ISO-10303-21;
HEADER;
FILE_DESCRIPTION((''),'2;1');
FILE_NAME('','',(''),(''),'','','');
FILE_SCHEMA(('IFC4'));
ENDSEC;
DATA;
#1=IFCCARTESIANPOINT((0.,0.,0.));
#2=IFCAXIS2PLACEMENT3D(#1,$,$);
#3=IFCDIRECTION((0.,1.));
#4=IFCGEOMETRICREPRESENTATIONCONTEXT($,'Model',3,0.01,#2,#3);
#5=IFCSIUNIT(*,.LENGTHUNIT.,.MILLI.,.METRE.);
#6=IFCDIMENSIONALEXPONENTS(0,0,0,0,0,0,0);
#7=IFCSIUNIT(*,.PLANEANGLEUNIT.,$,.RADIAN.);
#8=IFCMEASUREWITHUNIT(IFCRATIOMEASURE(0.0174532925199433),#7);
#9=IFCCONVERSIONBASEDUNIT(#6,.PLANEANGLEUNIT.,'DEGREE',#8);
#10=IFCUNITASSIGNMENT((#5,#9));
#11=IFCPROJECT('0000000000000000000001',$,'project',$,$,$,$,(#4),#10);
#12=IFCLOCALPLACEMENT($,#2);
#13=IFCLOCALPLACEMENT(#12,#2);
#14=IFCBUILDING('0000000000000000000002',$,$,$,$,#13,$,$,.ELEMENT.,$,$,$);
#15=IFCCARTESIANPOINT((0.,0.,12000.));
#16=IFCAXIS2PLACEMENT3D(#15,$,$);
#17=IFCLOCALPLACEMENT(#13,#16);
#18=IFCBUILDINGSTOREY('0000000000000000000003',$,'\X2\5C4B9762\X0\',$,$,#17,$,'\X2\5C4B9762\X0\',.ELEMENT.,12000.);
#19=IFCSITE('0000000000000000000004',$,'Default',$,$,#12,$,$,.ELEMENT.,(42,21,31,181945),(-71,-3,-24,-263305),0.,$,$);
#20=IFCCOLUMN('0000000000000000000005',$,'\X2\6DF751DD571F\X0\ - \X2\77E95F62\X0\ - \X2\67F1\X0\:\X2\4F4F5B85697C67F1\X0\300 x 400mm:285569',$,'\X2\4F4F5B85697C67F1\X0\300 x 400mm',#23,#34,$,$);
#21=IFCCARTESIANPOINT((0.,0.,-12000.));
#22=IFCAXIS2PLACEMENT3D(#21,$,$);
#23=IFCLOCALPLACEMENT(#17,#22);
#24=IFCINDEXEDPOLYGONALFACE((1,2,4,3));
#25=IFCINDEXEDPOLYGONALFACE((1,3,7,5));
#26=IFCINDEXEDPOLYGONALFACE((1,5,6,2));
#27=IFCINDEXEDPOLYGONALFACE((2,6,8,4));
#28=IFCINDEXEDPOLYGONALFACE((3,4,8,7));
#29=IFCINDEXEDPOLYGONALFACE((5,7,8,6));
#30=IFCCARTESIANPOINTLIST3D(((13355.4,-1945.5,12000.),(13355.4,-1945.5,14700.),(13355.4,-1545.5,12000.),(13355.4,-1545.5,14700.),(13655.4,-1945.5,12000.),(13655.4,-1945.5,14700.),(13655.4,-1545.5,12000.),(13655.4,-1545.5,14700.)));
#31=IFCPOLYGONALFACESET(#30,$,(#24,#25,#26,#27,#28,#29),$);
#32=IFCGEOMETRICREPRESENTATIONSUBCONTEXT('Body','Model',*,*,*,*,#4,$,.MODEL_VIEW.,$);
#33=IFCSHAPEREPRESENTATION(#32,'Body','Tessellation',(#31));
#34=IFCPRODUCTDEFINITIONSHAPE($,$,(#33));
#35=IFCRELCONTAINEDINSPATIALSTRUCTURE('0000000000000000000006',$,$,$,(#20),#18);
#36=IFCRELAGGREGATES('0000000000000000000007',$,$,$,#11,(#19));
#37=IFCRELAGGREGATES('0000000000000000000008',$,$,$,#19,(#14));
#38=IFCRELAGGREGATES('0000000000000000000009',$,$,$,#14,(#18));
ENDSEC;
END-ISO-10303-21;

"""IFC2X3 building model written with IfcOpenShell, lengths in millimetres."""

from ifc_helpers import new_model, entity, si_unit, converted_unit, direction, frame, origin, origin_2d_with_axis, place, context, subcontext, project, spatial, rectangle, extrude, source, transform, mapped, element, save


model = new_model("IFC2X3")

# Units and contexts
model_context = context("Model", 3, precision=0.01, world=origin(), true_north=direction((0.0, 1.0)))
body_context = subcontext(model_context, "Body", "Model", "MODEL_VIEW")
ifc_project = project(units=[si_unit("LENGTHUNIT", "METRE", prefix="MILLI"), converted_unit("PLANEANGLEUNIT", "DEGREE", entity("IfcRatioMeasure", 0.0174532925199433), si_unit("PLANEANGLEUNIT", "RADIAN"), dimensions=[0, 0, 0, 0, 0, 0, 0])], contexts=[model_context])

# Site, building, storey
site_placement = place(None, origin())
site = spatial("IfcSite", under=ifc_project, at=site_placement, Name="Default", CompositionType="ELEMENT", RefLatitude=(42, 21, 31, 181945), RefLongitude=(-71, -3, -24, -263305), RefElevation=0.0)
building_placement = place(site_placement, origin())
building = spatial("IfcBuilding", under=site, at=building_placement, CompositionType="ELEMENT")
storey_placement = place(building_placement, frame((0.0, 0.0, 12000.0)))
storey = spatial("IfcBuildingStorey", under=building, at=storey_placement, Name="屋面", LongName="屋面", CompositionType="ELEMENT", Elevation=12000.0)

# Column
shared_shape = source(origin(), body_context, "Body", "SweptSolid", [
    extrude(rectangle(XDim=400.0, YDim=300.0, at=origin_2d_with_axis()), frame((13505.4, -1745.5, 12000.0), z_axis=(0.0, 0.0, 1.0), x_axis=(0.0, -1.0, 0.0)), (0.0, 0.0, 1.0), 2700.0),
])
column_placement = place(storey_placement, frame((0.0, 0.0, -12000.0)))
element("IfcColumn", 1, at=column_placement, inside=storey, Name="混凝土 - 矩形 - 柱:住宅楼柱300 x 400mm:285569", ObjectType="住宅楼柱300 x 400mm", context=body_context, shape_type="MappedRepresentation", body=[
    mapped(shared_shape, transform((0.0, 0.0, 0.0), scale=1.0)),
])

save(model, "model.ifc")
